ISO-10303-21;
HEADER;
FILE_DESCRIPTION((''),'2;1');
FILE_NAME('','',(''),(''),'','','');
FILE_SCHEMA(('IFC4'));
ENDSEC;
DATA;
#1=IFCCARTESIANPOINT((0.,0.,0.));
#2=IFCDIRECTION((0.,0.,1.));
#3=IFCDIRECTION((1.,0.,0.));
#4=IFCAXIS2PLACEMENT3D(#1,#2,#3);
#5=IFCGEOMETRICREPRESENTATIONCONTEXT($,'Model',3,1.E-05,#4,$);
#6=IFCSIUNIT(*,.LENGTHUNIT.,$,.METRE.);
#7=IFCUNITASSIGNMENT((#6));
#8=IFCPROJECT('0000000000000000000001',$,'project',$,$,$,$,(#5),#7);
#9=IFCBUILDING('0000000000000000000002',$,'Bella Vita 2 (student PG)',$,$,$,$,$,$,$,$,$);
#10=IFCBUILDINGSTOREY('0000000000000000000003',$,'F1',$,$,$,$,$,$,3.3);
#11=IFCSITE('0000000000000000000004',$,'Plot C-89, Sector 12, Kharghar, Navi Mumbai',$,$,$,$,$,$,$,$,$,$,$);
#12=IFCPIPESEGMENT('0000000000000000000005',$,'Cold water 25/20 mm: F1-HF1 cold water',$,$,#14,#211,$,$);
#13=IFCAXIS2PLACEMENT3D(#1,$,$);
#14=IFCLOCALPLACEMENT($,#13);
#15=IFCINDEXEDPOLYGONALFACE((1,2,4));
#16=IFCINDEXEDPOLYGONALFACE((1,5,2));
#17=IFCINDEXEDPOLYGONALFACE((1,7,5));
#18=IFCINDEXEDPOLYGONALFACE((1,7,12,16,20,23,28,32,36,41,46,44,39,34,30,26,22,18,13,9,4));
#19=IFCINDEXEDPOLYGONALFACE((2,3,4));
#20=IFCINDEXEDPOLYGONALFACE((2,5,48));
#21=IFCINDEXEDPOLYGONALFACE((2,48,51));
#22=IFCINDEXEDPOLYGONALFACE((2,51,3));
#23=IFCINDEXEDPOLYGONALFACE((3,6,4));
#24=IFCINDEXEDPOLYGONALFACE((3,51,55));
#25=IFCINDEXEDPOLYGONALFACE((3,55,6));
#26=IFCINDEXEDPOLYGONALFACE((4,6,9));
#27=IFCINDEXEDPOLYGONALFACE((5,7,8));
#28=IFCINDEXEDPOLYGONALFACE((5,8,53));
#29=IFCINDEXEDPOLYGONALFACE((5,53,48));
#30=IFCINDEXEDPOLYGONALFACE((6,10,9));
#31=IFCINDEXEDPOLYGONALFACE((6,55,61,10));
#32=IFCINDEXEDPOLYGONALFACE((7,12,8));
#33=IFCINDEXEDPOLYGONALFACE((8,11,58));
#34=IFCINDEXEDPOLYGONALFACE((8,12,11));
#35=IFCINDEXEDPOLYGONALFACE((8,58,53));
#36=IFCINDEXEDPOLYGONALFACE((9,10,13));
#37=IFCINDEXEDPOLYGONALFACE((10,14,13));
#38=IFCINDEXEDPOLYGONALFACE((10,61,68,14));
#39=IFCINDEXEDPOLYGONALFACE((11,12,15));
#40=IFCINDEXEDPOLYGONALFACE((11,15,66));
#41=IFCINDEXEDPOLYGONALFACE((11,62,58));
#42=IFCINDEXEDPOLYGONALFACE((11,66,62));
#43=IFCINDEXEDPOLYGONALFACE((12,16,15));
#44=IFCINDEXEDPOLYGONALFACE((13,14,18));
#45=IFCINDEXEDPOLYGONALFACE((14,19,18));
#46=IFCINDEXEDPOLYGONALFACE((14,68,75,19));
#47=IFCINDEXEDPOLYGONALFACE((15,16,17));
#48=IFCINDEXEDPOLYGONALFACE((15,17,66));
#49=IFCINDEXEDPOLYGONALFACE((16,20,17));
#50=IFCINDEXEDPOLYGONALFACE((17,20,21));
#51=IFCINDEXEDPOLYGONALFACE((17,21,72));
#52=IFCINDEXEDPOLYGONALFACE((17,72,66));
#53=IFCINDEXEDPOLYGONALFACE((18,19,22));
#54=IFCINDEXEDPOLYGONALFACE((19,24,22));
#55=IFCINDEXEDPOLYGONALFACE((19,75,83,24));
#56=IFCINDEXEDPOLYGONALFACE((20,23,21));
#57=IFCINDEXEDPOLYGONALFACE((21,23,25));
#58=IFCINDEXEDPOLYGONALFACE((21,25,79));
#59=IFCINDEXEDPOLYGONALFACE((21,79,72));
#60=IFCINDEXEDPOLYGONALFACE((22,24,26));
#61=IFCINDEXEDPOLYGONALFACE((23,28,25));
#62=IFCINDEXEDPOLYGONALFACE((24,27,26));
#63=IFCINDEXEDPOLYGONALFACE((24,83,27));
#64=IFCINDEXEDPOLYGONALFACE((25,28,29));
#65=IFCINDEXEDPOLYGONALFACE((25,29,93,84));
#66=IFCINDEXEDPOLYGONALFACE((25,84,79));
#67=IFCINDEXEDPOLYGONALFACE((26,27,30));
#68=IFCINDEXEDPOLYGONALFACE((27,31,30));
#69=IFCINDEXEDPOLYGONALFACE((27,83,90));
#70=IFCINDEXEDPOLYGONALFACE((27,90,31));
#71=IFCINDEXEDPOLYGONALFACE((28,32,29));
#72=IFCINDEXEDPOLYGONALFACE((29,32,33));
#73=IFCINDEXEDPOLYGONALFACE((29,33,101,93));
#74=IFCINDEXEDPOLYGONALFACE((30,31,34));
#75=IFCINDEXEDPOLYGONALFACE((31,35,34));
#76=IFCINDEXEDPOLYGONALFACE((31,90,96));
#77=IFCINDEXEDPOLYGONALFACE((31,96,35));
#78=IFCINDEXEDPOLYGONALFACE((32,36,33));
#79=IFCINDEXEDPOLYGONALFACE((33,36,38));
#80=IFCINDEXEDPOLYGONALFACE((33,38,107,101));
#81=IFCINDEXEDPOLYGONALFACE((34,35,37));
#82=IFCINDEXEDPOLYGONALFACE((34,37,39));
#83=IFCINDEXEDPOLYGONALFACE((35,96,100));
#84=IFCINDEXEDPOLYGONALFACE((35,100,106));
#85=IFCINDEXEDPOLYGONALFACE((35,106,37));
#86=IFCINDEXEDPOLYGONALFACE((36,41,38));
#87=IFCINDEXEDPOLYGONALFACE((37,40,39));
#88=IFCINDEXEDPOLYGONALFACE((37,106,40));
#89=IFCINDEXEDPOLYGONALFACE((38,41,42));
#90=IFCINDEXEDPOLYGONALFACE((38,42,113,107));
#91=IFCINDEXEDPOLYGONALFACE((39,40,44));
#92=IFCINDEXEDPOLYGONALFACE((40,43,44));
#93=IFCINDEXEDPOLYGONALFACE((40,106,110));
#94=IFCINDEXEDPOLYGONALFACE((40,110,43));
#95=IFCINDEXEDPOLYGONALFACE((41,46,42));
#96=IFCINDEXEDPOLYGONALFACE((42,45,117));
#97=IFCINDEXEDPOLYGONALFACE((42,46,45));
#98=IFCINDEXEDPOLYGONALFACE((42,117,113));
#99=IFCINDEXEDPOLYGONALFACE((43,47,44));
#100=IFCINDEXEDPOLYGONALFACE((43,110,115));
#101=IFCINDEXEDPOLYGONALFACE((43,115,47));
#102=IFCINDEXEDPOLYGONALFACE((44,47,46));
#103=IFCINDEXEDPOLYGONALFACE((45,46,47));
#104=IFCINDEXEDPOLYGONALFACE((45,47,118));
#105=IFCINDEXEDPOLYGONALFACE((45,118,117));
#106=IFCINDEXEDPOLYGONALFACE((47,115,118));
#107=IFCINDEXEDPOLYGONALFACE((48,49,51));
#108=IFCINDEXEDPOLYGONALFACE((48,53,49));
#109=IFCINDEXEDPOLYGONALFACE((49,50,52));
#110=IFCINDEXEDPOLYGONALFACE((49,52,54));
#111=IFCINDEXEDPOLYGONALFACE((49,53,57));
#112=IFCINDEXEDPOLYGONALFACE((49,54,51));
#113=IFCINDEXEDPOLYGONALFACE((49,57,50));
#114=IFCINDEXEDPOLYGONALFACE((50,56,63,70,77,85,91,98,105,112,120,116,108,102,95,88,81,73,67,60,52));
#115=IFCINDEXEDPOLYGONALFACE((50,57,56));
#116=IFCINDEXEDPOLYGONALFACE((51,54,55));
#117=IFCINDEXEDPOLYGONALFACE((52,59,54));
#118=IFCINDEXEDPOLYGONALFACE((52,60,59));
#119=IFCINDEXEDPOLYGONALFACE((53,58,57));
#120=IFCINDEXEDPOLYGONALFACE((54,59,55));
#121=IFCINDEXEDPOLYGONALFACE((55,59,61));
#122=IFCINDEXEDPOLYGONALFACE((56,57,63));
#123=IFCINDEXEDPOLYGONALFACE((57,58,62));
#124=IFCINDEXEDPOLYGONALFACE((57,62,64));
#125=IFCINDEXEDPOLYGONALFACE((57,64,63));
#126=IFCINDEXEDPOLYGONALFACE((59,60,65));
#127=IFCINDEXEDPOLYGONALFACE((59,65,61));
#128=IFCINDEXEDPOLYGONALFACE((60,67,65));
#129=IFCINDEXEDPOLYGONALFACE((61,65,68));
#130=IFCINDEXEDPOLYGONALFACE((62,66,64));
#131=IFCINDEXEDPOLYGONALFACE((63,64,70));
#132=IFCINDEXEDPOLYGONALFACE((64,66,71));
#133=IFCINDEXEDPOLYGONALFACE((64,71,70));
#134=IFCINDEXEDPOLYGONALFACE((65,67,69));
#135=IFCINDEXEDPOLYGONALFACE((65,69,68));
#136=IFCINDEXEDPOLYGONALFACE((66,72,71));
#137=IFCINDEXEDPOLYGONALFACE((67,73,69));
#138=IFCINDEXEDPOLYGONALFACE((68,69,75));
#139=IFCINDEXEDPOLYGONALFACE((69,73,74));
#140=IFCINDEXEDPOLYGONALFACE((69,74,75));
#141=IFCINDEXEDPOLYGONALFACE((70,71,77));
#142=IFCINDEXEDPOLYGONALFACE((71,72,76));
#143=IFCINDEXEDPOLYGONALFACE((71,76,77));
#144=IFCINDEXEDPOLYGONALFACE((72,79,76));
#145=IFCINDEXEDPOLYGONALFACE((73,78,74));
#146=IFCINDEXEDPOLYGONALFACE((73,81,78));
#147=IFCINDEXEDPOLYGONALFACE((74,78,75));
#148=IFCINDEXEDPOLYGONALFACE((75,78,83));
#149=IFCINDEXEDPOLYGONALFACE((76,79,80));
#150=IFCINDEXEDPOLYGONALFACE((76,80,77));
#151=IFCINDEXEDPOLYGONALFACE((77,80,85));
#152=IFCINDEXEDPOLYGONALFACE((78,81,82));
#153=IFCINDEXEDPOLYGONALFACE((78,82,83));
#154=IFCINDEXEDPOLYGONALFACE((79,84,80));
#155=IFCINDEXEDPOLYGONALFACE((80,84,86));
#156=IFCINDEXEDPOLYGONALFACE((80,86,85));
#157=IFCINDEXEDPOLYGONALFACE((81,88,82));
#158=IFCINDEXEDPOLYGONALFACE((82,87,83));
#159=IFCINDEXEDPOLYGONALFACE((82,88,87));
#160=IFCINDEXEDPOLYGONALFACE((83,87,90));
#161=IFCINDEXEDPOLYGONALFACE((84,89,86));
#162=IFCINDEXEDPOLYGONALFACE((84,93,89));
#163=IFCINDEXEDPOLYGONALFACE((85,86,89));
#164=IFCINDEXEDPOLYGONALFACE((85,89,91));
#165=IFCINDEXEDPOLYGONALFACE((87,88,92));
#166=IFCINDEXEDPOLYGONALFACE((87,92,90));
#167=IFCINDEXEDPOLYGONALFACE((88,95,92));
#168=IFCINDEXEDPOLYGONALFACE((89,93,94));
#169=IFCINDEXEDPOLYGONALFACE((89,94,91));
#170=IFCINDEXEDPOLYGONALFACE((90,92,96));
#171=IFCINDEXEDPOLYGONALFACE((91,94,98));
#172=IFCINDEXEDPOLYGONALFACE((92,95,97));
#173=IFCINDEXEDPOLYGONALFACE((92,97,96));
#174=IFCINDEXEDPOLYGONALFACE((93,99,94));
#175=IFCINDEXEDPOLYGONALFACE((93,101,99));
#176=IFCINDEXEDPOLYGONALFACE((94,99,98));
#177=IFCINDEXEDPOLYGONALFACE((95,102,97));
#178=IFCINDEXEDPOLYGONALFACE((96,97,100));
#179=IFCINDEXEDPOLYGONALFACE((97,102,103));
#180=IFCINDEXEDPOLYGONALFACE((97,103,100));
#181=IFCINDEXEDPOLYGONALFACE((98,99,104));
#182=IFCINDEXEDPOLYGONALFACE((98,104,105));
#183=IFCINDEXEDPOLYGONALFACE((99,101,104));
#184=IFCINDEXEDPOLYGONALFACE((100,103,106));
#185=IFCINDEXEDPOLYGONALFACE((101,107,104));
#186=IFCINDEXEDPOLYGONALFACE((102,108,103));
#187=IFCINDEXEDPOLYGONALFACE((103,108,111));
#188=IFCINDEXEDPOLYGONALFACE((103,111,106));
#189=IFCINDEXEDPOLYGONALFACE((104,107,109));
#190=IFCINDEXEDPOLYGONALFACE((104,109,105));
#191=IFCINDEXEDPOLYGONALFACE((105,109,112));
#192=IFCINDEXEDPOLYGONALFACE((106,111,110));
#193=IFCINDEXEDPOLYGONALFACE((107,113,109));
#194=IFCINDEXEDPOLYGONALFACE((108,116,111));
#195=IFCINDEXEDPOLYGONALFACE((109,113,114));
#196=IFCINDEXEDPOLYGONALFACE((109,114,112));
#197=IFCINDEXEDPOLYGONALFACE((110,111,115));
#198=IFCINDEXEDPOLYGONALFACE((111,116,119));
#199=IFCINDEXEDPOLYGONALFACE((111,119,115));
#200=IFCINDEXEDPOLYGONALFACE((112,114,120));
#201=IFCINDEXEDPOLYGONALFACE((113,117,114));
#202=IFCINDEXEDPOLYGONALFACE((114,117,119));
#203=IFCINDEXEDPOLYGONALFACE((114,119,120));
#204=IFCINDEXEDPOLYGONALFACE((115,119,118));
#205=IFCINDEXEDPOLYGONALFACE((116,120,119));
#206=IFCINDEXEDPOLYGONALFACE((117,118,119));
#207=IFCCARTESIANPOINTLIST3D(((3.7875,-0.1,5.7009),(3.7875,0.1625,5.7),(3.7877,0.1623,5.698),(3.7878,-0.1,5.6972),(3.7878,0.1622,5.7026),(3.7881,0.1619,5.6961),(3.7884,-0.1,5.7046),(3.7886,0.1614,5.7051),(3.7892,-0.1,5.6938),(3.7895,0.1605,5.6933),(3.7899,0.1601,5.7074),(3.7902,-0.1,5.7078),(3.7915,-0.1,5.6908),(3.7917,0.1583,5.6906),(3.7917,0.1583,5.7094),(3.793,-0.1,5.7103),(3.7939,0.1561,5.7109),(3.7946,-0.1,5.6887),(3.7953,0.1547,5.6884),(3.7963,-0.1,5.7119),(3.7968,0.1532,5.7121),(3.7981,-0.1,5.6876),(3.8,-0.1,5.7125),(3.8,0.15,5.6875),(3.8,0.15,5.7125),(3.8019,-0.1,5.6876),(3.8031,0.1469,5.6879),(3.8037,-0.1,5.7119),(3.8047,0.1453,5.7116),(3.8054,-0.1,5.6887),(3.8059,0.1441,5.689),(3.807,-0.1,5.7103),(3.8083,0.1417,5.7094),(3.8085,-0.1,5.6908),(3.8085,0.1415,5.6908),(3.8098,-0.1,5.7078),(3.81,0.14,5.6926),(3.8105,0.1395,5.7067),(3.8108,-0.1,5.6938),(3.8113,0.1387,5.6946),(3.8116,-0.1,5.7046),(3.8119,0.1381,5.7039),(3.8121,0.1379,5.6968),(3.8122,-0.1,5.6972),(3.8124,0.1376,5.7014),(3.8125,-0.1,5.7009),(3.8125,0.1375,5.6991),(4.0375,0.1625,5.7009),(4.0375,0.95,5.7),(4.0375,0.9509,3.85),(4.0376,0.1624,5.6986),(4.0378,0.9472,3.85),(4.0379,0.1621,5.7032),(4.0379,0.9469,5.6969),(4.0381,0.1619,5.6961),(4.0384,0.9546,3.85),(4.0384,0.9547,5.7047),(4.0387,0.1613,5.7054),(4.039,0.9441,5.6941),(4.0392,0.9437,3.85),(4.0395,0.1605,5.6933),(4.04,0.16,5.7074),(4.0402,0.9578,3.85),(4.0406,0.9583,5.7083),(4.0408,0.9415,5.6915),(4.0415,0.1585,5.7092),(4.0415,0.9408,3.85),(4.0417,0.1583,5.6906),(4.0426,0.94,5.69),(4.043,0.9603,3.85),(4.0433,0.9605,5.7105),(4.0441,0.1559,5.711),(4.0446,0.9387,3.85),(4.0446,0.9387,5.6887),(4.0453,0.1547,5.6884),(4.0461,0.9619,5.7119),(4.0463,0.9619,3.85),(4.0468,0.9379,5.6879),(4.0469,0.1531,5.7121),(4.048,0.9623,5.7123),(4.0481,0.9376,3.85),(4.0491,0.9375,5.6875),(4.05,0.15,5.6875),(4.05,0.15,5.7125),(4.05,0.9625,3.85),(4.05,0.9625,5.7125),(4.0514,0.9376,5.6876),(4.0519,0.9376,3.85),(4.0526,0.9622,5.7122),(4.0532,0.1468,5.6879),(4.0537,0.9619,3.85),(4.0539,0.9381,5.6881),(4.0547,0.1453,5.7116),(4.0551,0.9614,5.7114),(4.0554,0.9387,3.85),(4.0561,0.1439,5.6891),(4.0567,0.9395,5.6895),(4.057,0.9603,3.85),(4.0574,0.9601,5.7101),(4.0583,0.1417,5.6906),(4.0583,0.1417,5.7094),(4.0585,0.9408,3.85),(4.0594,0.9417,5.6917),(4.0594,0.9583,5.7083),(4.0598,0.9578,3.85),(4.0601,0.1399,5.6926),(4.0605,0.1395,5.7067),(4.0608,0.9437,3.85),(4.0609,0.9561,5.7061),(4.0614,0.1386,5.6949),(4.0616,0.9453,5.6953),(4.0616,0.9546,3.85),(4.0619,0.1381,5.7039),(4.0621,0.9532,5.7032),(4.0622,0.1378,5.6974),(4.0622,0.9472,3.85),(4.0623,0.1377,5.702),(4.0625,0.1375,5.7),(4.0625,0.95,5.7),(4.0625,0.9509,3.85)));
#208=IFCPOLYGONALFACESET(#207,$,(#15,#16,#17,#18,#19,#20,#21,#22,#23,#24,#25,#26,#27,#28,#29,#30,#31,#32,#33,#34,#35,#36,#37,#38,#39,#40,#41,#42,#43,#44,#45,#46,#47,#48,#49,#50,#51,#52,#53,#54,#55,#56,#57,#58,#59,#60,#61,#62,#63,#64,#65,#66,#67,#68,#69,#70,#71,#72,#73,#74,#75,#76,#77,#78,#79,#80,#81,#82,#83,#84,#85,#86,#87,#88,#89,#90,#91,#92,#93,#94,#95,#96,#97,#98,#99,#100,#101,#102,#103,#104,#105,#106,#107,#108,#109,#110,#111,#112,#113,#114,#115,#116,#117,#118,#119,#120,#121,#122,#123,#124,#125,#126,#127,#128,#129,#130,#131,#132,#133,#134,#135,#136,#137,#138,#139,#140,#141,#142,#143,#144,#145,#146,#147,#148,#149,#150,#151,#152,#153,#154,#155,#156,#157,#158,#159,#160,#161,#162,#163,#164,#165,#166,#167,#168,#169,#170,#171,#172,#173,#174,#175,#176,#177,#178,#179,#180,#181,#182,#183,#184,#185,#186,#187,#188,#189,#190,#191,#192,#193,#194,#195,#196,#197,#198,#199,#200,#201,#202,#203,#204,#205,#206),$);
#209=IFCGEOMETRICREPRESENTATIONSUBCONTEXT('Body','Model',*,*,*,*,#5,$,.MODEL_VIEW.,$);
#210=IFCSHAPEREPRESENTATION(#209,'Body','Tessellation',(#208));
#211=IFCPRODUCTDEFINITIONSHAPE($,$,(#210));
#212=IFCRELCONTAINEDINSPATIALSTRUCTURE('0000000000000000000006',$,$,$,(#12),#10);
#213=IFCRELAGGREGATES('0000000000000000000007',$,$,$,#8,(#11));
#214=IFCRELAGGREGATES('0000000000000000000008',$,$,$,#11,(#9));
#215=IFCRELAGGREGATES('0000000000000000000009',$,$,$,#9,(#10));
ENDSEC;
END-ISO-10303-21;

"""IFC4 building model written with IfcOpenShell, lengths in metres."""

from ifc_helpers import new_model, entity, si_unit, origin, origin_with_axes, place, context, subcontext, project, spatial, element, save


model = new_model("IFC4")

# Units and contexts
model_context = context("Model", 3, precision=1e-05, world=origin_with_axes())
body_context = subcontext(model_context, "Body", "Model", "MODEL_VIEW")
ifc_project = project(units=[si_unit("LENGTHUNIT", "METRE")], contexts=[model_context])

# Site, building, storey
site = spatial("IfcSite", under=ifc_project, Name="Plot C-89, Sector 12, Kharghar, Navi Mumbai")
building = spatial("IfcBuilding", under=site, Name="Bella Vita 2 (student PG)")
storey = spatial("IfcBuildingStorey", under=building, Name="F1", Elevation=3.3)

# Pipe segment
pipe_segment_1_placement = place(None, origin())
element("IfcPipeSegment", 1, at=pipe_segment_1_placement, inside=storey, Name="Cold water 25/20 mm: F1-HF1 cold water", context=body_context, shape_type="AdvancedSweptSolid", body=[
    entity("IfcSweptDiskSolid", entity("IfcPolyline", [entity("IfcCartesianPoint", [3.8, -0.1, 5.7]), entity("IfcCartesianPoint", [3.8, 0.15, 5.7]), entity("IfcCartesianPoint", [4.05, 0.15, 5.7]), entity("IfcCartesianPoint", [4.05, 0.95, 5.7]), entity("IfcCartesianPoint", [4.05, 0.95, 3.85])]), 0.0125),
])

save(model, "model.ifc")
